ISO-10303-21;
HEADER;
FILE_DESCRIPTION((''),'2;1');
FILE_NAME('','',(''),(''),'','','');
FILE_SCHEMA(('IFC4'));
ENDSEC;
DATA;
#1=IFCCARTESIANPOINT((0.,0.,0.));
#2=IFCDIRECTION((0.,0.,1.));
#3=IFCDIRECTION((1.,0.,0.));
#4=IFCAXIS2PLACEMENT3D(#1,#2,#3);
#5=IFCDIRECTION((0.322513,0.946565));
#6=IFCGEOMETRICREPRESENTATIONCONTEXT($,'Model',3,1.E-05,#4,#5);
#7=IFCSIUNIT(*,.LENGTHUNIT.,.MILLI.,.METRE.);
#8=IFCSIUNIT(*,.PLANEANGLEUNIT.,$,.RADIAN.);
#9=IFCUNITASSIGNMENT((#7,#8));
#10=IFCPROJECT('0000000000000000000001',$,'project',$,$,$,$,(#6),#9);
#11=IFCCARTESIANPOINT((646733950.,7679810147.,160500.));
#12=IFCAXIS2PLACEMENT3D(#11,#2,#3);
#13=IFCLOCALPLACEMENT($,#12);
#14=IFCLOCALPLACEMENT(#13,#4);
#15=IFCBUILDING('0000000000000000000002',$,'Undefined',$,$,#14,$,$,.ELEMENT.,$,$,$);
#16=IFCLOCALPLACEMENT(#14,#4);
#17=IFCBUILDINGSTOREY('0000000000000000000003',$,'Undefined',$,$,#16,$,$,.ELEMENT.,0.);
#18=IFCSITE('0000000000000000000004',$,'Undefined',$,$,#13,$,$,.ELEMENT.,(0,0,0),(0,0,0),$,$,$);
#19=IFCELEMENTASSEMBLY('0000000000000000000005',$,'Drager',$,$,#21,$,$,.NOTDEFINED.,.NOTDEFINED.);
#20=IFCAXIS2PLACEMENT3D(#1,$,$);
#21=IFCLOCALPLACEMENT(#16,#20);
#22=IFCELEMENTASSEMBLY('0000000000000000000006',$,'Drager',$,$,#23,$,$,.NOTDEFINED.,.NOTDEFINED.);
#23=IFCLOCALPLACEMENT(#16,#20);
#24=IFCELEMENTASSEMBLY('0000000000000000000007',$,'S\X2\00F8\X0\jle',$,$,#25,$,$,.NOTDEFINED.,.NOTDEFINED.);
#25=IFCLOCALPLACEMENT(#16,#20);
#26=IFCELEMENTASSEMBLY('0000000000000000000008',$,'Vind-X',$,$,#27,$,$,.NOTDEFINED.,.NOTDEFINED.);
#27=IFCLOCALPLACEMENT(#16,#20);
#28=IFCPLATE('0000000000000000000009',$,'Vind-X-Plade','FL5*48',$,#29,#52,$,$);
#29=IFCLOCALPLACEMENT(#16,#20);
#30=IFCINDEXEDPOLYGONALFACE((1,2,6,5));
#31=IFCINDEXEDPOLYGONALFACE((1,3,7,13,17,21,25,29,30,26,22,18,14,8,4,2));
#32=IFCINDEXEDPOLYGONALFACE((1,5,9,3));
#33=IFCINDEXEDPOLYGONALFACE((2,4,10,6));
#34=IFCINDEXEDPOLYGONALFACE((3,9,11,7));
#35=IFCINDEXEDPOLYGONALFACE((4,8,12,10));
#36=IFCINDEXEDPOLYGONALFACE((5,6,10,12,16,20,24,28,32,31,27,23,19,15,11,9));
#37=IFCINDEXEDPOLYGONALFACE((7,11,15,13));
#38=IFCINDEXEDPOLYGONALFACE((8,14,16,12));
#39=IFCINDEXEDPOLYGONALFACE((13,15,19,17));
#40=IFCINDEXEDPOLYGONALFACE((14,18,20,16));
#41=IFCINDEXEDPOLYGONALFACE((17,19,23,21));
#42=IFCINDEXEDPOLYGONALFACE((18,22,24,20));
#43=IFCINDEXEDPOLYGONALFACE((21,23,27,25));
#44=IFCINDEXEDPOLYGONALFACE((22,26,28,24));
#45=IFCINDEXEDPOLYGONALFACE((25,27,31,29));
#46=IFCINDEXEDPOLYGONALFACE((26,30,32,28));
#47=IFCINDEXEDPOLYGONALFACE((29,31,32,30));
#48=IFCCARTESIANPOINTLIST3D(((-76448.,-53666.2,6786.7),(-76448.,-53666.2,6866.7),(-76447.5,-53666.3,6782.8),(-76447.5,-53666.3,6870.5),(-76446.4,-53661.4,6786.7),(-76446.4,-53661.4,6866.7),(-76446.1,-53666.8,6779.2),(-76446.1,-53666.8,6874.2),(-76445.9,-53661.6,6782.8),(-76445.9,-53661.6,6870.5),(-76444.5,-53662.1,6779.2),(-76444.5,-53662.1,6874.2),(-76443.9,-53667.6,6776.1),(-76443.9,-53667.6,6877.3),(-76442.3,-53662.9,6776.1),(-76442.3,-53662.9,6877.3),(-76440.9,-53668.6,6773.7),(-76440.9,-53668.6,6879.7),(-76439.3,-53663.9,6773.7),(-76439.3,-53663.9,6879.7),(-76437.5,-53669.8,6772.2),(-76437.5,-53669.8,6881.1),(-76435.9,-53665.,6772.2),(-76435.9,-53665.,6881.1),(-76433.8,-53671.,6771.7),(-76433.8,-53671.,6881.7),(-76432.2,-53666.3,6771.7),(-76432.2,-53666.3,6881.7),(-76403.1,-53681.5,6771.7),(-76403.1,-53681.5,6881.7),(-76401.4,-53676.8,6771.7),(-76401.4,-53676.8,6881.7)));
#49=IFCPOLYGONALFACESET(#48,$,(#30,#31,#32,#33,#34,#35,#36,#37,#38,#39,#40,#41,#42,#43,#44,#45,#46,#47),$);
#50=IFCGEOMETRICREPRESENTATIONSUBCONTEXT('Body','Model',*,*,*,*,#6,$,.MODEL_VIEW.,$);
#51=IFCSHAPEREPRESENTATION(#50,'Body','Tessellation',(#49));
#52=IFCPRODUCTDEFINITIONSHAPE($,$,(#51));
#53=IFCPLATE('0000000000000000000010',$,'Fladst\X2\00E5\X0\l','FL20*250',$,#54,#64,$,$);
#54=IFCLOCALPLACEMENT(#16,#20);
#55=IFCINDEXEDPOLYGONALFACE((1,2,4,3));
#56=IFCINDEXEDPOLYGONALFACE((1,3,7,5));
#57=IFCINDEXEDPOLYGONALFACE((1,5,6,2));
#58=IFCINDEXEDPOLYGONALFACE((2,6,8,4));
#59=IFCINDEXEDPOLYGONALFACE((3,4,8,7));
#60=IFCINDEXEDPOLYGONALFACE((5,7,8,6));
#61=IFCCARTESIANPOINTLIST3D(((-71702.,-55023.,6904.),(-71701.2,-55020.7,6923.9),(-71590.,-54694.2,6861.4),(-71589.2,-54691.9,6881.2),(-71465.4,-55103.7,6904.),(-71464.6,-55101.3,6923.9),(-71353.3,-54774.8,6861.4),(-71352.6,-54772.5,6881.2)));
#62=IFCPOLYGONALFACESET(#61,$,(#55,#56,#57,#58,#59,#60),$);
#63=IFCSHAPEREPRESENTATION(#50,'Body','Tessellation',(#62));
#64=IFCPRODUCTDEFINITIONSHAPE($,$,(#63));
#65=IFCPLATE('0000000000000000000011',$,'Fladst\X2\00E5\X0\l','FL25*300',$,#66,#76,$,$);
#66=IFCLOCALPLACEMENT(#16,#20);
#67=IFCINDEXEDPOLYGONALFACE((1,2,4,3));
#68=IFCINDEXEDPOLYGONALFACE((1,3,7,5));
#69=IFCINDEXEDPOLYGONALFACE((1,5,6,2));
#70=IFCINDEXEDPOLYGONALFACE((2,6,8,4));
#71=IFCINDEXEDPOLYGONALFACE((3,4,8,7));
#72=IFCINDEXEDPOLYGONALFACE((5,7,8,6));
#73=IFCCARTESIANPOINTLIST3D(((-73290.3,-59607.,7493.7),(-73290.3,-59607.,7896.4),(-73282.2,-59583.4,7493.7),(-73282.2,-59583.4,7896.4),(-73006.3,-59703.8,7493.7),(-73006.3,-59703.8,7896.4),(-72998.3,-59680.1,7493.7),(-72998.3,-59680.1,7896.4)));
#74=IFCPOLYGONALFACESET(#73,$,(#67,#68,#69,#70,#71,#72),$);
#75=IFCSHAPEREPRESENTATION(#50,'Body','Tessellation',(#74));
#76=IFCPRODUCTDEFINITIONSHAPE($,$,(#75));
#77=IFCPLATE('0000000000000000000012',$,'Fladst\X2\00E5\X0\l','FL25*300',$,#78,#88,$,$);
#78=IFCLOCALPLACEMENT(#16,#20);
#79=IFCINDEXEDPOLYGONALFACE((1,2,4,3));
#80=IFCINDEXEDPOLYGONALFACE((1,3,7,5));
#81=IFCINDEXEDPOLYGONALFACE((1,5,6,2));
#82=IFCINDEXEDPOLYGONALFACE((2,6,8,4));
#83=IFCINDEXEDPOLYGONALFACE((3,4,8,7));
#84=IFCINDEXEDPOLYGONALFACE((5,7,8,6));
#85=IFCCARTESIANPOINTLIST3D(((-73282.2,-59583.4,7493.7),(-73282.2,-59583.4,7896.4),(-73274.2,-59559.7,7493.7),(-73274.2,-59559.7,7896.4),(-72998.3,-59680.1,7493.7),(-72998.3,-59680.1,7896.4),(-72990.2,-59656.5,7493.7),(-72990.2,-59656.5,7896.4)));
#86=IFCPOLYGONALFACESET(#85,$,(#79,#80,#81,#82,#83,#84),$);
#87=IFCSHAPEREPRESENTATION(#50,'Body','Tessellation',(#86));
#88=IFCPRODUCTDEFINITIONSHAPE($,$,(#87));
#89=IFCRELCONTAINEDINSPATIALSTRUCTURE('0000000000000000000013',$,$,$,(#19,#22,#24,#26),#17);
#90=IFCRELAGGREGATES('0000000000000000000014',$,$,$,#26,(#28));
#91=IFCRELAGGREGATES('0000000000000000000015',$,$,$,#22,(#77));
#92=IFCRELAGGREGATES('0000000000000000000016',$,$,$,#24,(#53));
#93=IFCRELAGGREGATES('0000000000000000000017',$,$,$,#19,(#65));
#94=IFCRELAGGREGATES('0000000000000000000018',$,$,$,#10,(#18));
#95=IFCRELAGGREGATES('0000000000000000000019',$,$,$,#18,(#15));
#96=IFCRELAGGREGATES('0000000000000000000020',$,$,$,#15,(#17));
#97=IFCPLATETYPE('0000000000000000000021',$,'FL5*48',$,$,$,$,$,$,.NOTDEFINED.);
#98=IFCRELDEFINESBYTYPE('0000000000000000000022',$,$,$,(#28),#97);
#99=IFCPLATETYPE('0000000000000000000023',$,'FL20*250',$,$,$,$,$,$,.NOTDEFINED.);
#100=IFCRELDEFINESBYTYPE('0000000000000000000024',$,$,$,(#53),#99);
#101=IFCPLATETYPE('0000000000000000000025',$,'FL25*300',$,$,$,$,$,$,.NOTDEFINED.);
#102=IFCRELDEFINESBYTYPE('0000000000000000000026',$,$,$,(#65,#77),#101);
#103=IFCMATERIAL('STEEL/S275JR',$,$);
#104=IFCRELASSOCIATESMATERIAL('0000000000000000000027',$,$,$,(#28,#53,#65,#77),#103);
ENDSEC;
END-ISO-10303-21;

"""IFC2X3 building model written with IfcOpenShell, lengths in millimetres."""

from ifc_helpers import new_model, si_unit, direction, frame, frame_2d, origin_with_axes, place, context, subcontext, project, spatial, polyline, circle_curve, parameter, trimmed, segment, composite_curve, outline, extrude, material, type_object, element, aggregate, save


model = new_model("IFC2X3")

# Units and contexts
model_context = context("Model", 3, precision=1e-05, world=origin_with_axes(), true_north=direction((0.322513, 0.946565)))
body_context = subcontext(model_context, "Body", "Model", "MODEL_VIEW")
ifc_project = project(units=[si_unit("LENGTHUNIT", "METRE", prefix="MILLI"), si_unit("PLANEANGLEUNIT", "RADIAN")], contexts=[model_context])

# Site, building, storey
site_placement = place(None, frame((646733950.0, 7679810147.0, 160500.0), z_axis=(0.0, 0.0, 1.0), x_axis=(1.0, 0.0, 0.0)))
site = spatial("IfcSite", under=ifc_project, at=site_placement, Name="Undefined", CompositionType="ELEMENT", RefLatitude=(0, 0, 0), RefLongitude=(0, 0, 0))
building_placement = place(site_placement, origin_with_axes())
building = spatial("IfcBuilding", under=site, at=building_placement, Name="Undefined", CompositionType="ELEMENT")
storey_placement = place(building_placement, origin_with_axes())
storey = spatial("IfcBuildingStorey", under=building, at=storey_placement, Name="Undefined", CompositionType="ELEMENT", Elevation=0.0)

# Element assemblies
assembly_1_placement = place(storey_placement, origin_with_axes())
assembly_1 = element("IfcElementAssembly", 1, at=assembly_1_placement, inside=storey, Name="Drager", AssemblyPlace="NOTDEFINED", PredefinedType="NOTDEFINED")
assembly_2_placement = place(storey_placement, origin_with_axes())
assembly_2 = element("IfcElementAssembly", 2, at=assembly_2_placement, inside=storey, Name="Drager", AssemblyPlace="NOTDEFINED", PredefinedType="NOTDEFINED")

# Shared definitions
ifc_material_1 = material(Name="STEEL/S275JR")

# Element assemblies
assembly_3_placement = place(storey_placement, origin_with_axes())
assembly_3 = element("IfcElementAssembly", 3, at=assembly_3_placement, inside=storey, Name="Søjle", AssemblyPlace="NOTDEFINED", PredefinedType="NOTDEFINED")
assembly_4_placement = place(storey_placement, origin_with_axes())
assembly_4 = element("IfcElementAssembly", 4, at=assembly_4_placement, inside=storey, Name="Vind-X", AssemblyPlace="NOTDEFINED", PredefinedType="NOTDEFINED")

# Plates
plate_type_1 = type_object("IfcPlateType", Name="FL5*48", PredefinedType="NOTDEFINED")
plate_1_placement = place(assembly_4_placement, frame((-76402.3, -53679.1, 6881.7), z_axis=(-0.322513, -0.946565, 0.0), x_axis=(-0.946565, 0.322513, 0.0)))
plate_1 = element("IfcPlate", 5, at=plate_1_placement, type_object=plate_type_1, material=ifc_material_1, Name="Vind-X-Plade", Description="FL5*48", context=body_context, shape_type="SweptSolid", body=[
    extrude(outline(composite_curve([segment(polyline([(0.0, 0.0), (32.5, 0.0)]), True, "CONTINUOUS"), segment(trimmed(circle_curve(frame_2d((32.5, 15.0), x_axis=(0.0, -1.0)), 15.0), [parameter(0.0)], [parameter(1.570796)], True, "PARAMETER"), True, "CONTINUOUS"), segment(polyline([(47.5, 15.0), (47.5, 95.0)]), True, "CONTINUOUS"), segment(trimmed(circle_curve(frame_2d((32.5, 95.0), x_axis=(1.0, 0.0)), 15.0), [parameter(0.0)], [parameter(1.570796)], True, "PARAMETER"), True, "CONTINUOUS"), segment(polyline([(32.5, 110.0), (0.0, 110.0), (0.0, 0.0)]), True, "CONTINUOUS")], self_intersect=True)), frame((0.0, 0.0, -2.5), z_axis=(0.0, 0.0, 1.0), x_axis=(1.0, 0.0, 0.0)), (0.0, 0.0, 1.0), 5.0),
])
aggregate(assembly_4, [plate_1])
plate_type_2 = type_object("IfcPlateType", Name="FL20*250", PredefinedType="NOTDEFINED")
plate_2_placement = place(assembly_3_placement, frame((-71471.3, -54733.4, 6871.3), z_axis=(-0.039304, -0.115357, -0.992546), x_axis=(-0.320109, -0.93951, 0.121869)))
plate_2 = element("IfcPlate", 6, at=plate_2_placement, type_object=plate_type_2, material=ifc_material_1, Name="Fladstål", Description="FL20*250", context=body_context, shape_type="SweptSolid", body=[
    extrude(outline(polyline([(0.0, -125.0), (0.0, 125.0), (350.0, 125.0), (350.0, -125.0), (0.0, -125.0)])), frame((0.0, 0.0, -10.0), z_axis=(0.0, 0.0, 1.0), x_axis=(1.0, 0.0, 0.0)), (0.0, 0.0, 1.0), 20.0),
])
plate_type_3 = type_object("IfcPlateType", Name="FL25*300", PredefinedType="NOTDEFINED")
plate_3_placement = place(assembly_1_placement, frame((-73144.3, -59643.6, 7493.7), z_axis=(-0.322513, -0.946565, 0.0), x_axis=(0.0, 0.0, 1.0)))
plate_3 = element("IfcPlate", 7, at=plate_3_placement, type_object=plate_type_3, material=ifc_material_1, Name="Fladstål", Description="FL25*300", context=body_context, shape_type="SweptSolid", body=[
    extrude(outline(polyline([(0.0, -150.0), (0.0, 150.0), (402.7, 150.0), (402.7, -150.0), (0.0, -150.0)])), frame((0.0, 0.0, -12.5), z_axis=(0.0, 0.0, 1.0), x_axis=(1.0, 0.0, 0.0)), (0.0, 0.0, 1.0), 25.0),
])
plate_4_placement = place(assembly_2_placement, frame((-73136.2, -59619.9, 7493.7), z_axis=(-0.322513, -0.946565, 0.0), x_axis=(0.0, 0.0, 1.0)))
plate_4 = element("IfcPlate", 8, at=plate_4_placement, type_object=plate_type_3, material=ifc_material_1, Name="Fladstål", Description="FL25*300", context=body_context, shape_type="SweptSolid", body=[
    extrude(outline(polyline([(0.0, -150.0), (0.0, 150.0), (402.7, 150.0), (402.7, -150.0), (0.0, -150.0)])), frame((0.0, 0.0, -12.5), z_axis=(0.0, 0.0, 1.0), x_axis=(1.0, 0.0, 0.0)), (0.0, 0.0, 1.0), 25.0),
])
aggregate(assembly_2, [plate_4])

aggregate(assembly_3, [plate_2])
aggregate(assembly_1, [plate_3])

save(model, "model.ifc")
